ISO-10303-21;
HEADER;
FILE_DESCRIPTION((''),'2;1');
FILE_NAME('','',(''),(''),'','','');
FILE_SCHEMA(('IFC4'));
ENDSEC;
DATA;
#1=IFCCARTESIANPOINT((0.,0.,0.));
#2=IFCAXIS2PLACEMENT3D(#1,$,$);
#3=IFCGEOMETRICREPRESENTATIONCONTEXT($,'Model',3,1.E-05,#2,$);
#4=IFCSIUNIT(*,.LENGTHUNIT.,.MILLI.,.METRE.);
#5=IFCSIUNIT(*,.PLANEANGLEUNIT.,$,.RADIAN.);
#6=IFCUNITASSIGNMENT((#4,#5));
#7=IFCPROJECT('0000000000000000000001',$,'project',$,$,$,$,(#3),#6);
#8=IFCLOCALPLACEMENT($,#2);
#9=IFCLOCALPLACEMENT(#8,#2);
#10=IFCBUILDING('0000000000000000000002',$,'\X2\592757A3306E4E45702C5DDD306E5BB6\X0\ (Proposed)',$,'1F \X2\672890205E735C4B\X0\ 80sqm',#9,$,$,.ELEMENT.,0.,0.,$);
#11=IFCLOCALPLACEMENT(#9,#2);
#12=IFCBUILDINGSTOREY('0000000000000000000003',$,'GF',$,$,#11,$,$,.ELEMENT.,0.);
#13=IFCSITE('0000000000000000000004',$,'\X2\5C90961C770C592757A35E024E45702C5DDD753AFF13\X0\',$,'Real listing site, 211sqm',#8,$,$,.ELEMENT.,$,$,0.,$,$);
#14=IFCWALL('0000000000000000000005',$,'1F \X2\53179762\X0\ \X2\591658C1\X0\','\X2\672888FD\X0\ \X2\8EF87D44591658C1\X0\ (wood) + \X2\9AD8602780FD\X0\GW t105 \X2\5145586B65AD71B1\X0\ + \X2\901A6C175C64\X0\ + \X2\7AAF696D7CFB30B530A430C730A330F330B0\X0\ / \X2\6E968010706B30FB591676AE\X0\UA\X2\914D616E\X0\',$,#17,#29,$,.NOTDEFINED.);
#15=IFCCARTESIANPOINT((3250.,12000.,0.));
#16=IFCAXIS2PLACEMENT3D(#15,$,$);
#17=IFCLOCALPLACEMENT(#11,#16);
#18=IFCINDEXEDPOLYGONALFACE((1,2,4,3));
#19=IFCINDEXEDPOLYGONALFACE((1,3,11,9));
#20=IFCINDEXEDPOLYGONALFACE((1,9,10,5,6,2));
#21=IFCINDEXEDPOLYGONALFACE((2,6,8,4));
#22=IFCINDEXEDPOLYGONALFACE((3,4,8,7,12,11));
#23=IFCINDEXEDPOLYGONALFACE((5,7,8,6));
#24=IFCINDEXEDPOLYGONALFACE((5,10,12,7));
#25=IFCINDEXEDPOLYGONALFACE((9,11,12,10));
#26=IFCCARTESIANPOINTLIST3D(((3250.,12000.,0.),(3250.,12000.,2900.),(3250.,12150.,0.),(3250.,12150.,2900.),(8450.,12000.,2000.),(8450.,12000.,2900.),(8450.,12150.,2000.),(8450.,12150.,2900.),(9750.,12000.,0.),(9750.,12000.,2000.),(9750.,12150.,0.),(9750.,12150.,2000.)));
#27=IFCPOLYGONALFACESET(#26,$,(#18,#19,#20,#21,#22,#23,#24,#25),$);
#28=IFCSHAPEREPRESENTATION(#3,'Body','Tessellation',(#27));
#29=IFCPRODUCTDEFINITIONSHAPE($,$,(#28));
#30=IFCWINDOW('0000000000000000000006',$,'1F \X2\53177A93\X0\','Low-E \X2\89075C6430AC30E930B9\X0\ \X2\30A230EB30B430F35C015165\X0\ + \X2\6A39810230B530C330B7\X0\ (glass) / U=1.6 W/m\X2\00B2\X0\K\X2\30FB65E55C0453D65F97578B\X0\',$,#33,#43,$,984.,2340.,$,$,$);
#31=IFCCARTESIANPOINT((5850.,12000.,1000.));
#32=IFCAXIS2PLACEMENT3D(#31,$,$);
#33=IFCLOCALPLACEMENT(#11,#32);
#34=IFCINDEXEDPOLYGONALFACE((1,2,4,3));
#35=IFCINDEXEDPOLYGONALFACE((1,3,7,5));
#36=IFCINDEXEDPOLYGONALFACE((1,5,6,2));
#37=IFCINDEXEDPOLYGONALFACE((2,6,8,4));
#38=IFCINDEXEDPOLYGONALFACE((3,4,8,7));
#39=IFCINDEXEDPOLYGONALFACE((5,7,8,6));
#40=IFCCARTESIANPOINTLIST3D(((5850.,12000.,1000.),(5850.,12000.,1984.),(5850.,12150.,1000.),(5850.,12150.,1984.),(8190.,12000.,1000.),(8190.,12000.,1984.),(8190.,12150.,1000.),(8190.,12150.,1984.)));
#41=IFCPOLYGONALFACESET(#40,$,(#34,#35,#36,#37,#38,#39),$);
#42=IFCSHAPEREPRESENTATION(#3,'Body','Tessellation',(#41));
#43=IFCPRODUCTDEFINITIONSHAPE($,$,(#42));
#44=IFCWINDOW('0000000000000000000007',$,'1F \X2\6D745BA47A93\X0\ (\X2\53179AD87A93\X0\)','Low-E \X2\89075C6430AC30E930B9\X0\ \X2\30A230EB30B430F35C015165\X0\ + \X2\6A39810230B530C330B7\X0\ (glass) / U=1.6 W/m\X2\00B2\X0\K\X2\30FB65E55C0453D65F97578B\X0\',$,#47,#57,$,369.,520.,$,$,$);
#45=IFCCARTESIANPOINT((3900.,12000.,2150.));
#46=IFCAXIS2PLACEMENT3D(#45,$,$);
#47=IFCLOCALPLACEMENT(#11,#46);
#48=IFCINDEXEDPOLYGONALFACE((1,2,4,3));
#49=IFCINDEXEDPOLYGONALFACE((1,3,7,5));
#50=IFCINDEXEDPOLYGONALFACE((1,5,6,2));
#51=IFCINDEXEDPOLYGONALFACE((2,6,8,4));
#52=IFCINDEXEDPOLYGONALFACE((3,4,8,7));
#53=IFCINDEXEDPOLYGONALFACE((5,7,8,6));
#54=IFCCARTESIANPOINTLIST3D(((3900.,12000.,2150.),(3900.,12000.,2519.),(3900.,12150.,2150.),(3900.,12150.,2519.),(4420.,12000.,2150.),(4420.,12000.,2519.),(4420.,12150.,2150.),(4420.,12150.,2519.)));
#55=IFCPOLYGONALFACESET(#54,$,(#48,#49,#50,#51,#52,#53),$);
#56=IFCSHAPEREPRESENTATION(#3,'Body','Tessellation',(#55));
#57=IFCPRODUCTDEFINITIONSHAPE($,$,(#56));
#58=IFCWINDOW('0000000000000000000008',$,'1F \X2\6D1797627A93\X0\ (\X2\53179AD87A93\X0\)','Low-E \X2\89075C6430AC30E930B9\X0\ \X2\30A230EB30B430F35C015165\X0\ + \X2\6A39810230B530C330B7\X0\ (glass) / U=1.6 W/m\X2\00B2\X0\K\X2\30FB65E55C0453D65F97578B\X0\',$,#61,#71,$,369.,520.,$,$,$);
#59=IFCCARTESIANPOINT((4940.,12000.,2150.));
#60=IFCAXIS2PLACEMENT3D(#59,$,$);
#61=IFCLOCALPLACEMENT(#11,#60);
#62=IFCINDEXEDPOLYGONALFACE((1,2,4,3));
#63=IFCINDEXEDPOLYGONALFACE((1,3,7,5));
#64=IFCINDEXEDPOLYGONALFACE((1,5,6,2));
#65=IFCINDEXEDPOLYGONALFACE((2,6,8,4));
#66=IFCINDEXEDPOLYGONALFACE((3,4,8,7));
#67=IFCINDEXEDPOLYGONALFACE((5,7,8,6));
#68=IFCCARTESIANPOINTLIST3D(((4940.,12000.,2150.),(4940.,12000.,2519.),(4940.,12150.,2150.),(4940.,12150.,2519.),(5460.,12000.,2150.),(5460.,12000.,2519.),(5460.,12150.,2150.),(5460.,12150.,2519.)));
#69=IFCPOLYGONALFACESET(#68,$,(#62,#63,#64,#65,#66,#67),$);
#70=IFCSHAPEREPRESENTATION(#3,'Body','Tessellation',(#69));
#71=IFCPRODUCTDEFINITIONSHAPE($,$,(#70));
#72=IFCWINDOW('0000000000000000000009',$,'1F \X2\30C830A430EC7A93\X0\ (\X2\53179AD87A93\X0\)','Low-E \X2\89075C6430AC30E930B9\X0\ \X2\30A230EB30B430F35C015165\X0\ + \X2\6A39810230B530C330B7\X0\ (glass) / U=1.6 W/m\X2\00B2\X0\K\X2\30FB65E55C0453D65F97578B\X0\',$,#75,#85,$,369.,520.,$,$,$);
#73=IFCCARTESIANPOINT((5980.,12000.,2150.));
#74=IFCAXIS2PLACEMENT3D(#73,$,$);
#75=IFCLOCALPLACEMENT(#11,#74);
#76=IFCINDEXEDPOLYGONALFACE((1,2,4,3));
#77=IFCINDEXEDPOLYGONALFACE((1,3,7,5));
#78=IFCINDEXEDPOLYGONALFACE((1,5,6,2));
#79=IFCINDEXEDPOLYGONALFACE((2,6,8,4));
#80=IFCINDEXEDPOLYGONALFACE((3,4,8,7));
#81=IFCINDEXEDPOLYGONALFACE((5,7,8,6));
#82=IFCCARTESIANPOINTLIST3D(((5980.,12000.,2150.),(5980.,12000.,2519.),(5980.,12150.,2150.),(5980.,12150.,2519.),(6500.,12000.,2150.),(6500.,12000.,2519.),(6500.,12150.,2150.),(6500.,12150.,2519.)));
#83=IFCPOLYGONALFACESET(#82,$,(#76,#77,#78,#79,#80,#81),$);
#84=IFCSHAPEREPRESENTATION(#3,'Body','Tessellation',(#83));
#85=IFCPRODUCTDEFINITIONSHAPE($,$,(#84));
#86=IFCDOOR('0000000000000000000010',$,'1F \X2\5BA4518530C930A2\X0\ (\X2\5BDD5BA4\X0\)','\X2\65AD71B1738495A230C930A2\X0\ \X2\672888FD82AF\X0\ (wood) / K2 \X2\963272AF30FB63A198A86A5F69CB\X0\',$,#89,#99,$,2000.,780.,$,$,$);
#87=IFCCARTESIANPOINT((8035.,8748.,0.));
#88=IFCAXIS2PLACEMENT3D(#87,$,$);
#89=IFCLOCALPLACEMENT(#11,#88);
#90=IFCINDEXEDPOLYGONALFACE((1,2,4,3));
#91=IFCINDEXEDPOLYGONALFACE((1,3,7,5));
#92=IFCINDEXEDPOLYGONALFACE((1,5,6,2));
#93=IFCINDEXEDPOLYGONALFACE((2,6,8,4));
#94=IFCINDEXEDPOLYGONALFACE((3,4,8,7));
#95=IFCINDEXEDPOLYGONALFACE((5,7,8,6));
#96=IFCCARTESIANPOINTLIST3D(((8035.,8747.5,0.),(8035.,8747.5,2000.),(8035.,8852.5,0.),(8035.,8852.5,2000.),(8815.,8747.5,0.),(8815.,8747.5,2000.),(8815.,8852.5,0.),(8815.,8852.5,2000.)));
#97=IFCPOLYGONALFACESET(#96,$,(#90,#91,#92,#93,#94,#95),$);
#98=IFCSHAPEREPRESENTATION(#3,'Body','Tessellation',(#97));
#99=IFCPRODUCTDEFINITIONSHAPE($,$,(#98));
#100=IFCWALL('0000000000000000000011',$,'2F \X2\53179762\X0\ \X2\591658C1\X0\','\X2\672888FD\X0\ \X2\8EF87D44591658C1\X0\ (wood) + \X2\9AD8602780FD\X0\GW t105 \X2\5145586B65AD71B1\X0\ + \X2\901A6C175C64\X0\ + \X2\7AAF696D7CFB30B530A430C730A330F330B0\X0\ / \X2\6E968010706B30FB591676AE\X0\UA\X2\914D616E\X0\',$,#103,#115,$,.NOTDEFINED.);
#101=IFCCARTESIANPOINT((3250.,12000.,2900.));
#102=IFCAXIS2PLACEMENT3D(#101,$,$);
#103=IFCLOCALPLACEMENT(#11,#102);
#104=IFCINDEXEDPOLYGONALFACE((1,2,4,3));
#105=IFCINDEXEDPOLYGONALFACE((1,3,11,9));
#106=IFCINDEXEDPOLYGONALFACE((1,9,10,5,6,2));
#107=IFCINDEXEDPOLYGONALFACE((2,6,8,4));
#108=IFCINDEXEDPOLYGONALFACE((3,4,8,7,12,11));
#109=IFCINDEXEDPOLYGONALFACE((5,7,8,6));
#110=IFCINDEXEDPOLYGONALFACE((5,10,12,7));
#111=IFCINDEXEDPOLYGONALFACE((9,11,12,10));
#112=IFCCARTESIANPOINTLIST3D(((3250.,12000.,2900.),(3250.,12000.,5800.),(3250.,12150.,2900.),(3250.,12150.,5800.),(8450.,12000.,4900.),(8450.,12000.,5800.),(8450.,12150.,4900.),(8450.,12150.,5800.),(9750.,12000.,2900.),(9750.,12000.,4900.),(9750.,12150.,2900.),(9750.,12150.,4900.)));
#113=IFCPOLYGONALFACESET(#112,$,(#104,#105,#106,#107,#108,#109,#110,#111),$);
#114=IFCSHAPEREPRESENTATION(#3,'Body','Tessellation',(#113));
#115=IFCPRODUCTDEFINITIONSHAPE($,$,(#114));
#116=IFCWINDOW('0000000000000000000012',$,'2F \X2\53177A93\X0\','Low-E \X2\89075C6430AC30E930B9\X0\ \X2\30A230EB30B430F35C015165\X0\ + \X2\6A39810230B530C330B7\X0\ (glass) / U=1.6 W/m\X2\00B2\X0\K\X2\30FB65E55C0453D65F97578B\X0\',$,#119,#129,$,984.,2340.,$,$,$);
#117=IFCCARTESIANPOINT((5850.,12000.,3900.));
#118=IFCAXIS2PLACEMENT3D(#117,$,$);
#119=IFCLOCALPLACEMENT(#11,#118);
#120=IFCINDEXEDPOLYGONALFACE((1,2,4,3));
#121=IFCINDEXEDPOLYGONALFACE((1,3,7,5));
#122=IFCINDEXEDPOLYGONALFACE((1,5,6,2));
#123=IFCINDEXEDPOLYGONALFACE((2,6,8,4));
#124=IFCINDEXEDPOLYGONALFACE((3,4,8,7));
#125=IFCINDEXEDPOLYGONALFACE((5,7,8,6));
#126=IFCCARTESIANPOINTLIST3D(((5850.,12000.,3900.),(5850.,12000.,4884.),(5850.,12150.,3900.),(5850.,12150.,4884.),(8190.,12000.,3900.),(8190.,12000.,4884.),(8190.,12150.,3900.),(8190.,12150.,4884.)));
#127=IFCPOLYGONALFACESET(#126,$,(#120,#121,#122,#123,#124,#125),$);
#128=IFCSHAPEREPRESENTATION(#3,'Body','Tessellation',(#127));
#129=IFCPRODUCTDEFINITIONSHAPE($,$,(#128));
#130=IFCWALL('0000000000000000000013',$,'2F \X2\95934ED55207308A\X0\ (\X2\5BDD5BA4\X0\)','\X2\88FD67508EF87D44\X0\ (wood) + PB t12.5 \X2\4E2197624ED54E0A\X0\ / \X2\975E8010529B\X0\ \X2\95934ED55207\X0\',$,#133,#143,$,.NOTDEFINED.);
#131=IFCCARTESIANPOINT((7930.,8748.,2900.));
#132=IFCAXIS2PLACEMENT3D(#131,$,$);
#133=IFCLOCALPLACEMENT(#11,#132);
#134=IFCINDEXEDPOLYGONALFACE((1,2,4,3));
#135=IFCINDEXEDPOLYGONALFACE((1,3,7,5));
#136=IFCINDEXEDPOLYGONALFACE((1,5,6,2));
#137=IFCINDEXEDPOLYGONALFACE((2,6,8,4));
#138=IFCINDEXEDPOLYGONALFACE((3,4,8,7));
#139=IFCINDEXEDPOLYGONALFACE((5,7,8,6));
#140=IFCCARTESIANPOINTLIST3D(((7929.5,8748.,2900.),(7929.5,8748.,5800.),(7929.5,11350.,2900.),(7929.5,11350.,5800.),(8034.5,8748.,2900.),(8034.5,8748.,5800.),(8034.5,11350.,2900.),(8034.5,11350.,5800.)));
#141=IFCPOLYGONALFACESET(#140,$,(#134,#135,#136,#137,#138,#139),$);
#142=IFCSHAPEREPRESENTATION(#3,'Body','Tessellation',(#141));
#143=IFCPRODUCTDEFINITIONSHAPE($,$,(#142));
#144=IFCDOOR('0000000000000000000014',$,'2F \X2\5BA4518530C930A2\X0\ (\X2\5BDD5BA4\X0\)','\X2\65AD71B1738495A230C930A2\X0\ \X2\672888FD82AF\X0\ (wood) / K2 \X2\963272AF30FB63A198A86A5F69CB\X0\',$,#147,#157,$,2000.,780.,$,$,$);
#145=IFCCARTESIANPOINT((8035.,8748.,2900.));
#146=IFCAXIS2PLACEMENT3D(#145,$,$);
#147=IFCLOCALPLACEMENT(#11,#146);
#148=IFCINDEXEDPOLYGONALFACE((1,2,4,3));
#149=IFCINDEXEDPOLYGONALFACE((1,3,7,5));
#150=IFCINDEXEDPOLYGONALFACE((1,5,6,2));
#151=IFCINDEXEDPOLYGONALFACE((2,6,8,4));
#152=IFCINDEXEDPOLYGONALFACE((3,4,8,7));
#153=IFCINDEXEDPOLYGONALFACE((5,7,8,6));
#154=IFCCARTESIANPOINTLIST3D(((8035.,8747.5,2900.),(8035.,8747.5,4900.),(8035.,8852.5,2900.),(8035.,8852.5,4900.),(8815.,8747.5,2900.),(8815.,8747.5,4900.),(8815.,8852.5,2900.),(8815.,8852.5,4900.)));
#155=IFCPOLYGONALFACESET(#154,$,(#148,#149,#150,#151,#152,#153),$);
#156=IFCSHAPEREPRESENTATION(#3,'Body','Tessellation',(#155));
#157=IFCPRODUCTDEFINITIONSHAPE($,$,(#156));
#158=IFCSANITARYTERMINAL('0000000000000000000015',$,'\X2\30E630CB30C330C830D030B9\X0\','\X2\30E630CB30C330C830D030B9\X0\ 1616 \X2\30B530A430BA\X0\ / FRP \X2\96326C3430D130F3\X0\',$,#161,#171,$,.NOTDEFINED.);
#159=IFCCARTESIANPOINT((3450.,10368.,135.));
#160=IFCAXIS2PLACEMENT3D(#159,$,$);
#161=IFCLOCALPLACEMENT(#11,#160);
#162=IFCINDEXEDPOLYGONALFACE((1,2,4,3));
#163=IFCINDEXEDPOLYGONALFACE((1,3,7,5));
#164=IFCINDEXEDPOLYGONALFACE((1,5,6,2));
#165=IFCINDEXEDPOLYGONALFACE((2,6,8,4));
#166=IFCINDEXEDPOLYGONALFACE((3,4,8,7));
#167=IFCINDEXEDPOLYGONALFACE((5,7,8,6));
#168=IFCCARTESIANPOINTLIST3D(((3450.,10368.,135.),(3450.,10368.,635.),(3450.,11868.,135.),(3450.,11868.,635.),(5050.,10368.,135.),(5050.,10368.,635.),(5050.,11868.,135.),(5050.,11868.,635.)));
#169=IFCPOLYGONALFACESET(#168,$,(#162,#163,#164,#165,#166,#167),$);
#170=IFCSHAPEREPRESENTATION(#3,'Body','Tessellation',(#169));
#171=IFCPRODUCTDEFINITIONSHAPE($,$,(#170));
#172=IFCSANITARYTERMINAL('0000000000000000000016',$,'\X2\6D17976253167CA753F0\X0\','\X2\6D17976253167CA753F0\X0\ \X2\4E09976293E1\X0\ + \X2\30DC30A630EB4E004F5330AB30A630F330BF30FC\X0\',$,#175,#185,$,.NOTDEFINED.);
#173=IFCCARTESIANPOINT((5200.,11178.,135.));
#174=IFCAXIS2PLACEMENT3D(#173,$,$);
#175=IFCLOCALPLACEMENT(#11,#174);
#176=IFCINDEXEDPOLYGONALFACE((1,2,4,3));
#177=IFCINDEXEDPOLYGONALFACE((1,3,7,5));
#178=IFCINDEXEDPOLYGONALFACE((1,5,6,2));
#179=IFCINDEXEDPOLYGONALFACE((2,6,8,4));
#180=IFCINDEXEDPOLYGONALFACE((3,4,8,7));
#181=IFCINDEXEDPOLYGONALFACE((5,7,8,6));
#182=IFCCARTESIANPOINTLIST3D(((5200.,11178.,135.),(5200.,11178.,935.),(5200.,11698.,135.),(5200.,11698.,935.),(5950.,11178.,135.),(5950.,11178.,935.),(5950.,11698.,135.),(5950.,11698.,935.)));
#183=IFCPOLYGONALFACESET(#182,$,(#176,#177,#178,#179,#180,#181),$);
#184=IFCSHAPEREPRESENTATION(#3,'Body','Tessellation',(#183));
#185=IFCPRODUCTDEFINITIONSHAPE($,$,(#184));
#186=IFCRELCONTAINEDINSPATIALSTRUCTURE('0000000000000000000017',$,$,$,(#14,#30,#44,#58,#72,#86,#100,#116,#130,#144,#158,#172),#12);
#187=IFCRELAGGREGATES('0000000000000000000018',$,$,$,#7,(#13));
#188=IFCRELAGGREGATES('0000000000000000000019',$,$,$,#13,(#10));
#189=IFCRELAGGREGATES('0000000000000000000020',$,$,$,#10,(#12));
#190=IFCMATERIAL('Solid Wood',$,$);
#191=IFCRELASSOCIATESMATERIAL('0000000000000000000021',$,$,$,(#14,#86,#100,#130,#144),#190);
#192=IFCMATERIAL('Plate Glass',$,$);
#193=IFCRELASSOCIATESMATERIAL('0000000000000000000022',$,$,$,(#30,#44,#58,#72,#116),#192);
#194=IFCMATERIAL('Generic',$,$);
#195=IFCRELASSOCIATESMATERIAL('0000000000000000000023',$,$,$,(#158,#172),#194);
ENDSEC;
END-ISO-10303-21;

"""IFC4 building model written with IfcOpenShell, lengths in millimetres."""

from ifc_helpers import new_model, si_unit, frame, frame_2d, origin, place, context, project, spatial, rectangle, extrude, material, element, fill, save


model = new_model("IFC4")

# Units and contexts
model_context = context("Model", 3, precision=1e-05, world=origin())
ifc_project = project(units=[si_unit("LENGTHUNIT", "METRE", prefix="MILLI"), si_unit("PLANEANGLEUNIT", "RADIAN")], contexts=[model_context])

# Site, building, storey
site_placement = place(None, origin())
site = spatial("IfcSite", under=ifc_project, at=site_placement, Name="岐阜県大垣市久瀬川町３", ObjectType="Real listing site, 211sqm", CompositionType="ELEMENT", RefElevation=0.0)
building_placement = place(site_placement, origin())
building = spatial("IfcBuilding", under=site, at=building_placement, Name="大垣の久瀬川の家 (Proposed)", ObjectType="1F 木造平屋 80sqm", CompositionType="ELEMENT", ElevationOfRefHeight=0.0, ElevationOfTerrain=0.0)
storey_placement = place(building_placement, origin())
storey = spatial("IfcBuildingStorey", under=building, at=storey_placement, Name="GF", CompositionType="ELEMENT", Elevation=0.0)

# Wall, openings, windows
ifc_material_1 = material(Name="Solid Wood")
wall_1_placement = place(storey_placement, frame((3250.0, 12000.0, 0.0)))
wall_1 = element("IfcWall", 1, at=wall_1_placement, inside=storey, material=ifc_material_1, Name="1F 北面 外壁", Description="木製 軸組外壁 (wood) + 高性能GW t105 充填断熱 + 通気層 + 窯業系サイディング / 準耐火・外皮UA配慮", PredefinedType="NOTDEFINED", context=model_context, shape_type="SweptSolid", body=[
    extrude(rectangle(XDim=6500.0, YDim=150.0, at=frame_2d((3250.0, 75.0))), frame((3250.0, 12000.0, 0.0)), (0.0, 0.0, 1.0), 2900.0),
])
opening_1_placement = place(storey_placement, frame((5850.0, 12000.0, 1000.0)))
opening_1 = element("IfcOpeningElement", 2, at=opening_1_placement, cuts=wall_1, PredefinedType="NOTDEFINED", context=model_context, shape_type="SweptSolid", body=[
    extrude(rectangle(XDim=2340.0, YDim=150.0, at=frame_2d((1170.0, 75.0))), frame((5850.0, 12000.0, 1000.0)), (0.0, 0.0, 1.0), 984.0),
])
opening_2_placement = place(storey_placement, frame((3900.0, 12000.0, 2150.0)))
opening_2 = element("IfcOpeningElement", 3, at=opening_2_placement, cuts=wall_1, PredefinedType="NOTDEFINED", context=model_context, shape_type="SweptSolid", body=[
    extrude(rectangle(XDim=520.0, YDim=150.0, at=frame_2d((260.0, 75.0))), frame((3900.0, 12000.0, 2150.0)), (0.0, 0.0, 1.0), 369.0),
])
opening_3_placement = place(storey_placement, frame((4940.0, 12000.0, 2150.0)))
opening_3 = element("IfcOpeningElement", 4, at=opening_3_placement, cuts=wall_1, PredefinedType="NOTDEFINED", context=model_context, shape_type="SweptSolid", body=[
    extrude(rectangle(XDim=520.0, YDim=150.0, at=frame_2d((260.0, 75.0))), frame((4940.0, 12000.0, 2150.0)), (0.0, 0.0, 1.0), 369.0),
])
opening_4_placement = place(storey_placement, frame((5980.0, 12000.0, 2150.0)))
opening_4 = element("IfcOpeningElement", 5, at=opening_4_placement, cuts=wall_1, PredefinedType="NOTDEFINED", context=model_context, shape_type="SweptSolid", body=[
    extrude(rectangle(XDim=520.0, YDim=150.0, at=frame_2d((260.0, 75.0))), frame((5980.0, 12000.0, 2150.0)), (0.0, 0.0, 1.0), 369.0),
])
ifc_material_2 = material(Name="Plate Glass")
window_1_placement = place(storey_placement, frame((5850.0, 12000.0, 1000.0)))
window_1 = element("IfcWindow", 6, at=window_1_placement, inside=storey, material=ifc_material_2, Name="1F 北窓", Description="Low-E 複層ガラス アルゴン封入 + 樹脂サッシ (glass) / U=1.6 W/m²K・日射取得型", OverallHeight=984.0, OverallWidth=2340.0, context=model_context, shape_type="SweptSolid", body=[
    extrude(rectangle(XDim=2340.0, YDim=150.0, at=frame_2d((1170.0, 75.0))), frame((5850.0, 12000.0, 1000.0)), (0.0, 0.0, 1.0), 984.0),
])
fill(opening_1, window_1)
window_2_placement = place(storey_placement, frame((3900.0, 12000.0, 2150.0)))
window_2 = element("IfcWindow", 7, at=window_2_placement, inside=storey, material=ifc_material_2, Name="1F 浴室窓 (北高窓)", Description="Low-E 複層ガラス アルゴン封入 + 樹脂サッシ (glass) / U=1.6 W/m²K・日射取得型", OverallHeight=369.0, OverallWidth=520.0, context=model_context, shape_type="SweptSolid", body=[
    extrude(rectangle(XDim=520.0, YDim=150.0, at=frame_2d((260.0, 75.0))), frame((3900.0, 12000.0, 2150.0)), (0.0, 0.0, 1.0), 369.0),
])
fill(opening_2, window_2)
window_3_placement = place(storey_placement, frame((4940.0, 12000.0, 2150.0)))
window_3 = element("IfcWindow", 8, at=window_3_placement, inside=storey, material=ifc_material_2, Name="1F 洗面窓 (北高窓)", Description="Low-E 複層ガラス アルゴン封入 + 樹脂サッシ (glass) / U=1.6 W/m²K・日射取得型", OverallHeight=369.0, OverallWidth=520.0, context=model_context, shape_type="SweptSolid", body=[
    extrude(rectangle(XDim=520.0, YDim=150.0, at=frame_2d((260.0, 75.0))), frame((4940.0, 12000.0, 2150.0)), (0.0, 0.0, 1.0), 369.0),
])
fill(opening_3, window_3)
window_4_placement = place(storey_placement, frame((5980.0, 12000.0, 2150.0)))
window_4 = element("IfcWindow", 9, at=window_4_placement, inside=storey, material=ifc_material_2, Name="1F トイレ窓 (北高窓)", Description="Low-E 複層ガラス アルゴン封入 + 樹脂サッシ (glass) / U=1.6 W/m²K・日射取得型", OverallHeight=369.0, OverallWidth=520.0, context=model_context, shape_type="SweptSolid", body=[
    extrude(rectangle(XDim=520.0, YDim=150.0, at=frame_2d((260.0, 75.0))), frame((5980.0, 12000.0, 2150.0)), (0.0, 0.0, 1.0), 369.0),
])
fill(opening_4, window_4)

# Door
door_1_placement = place(storey_placement, frame((8035.0, 8748.0, 0.0)))
element("IfcDoor", 10, at=door_1_placement, inside=storey, material=ifc_material_1, Name="1F 室内ドア (寝室)", Description="断熱玄関ドア 木製芯 (wood) / K2 防犯・採風機構", OverallHeight=2000.0, OverallWidth=780.0, context=model_context, shape_type="SweptSolid", body=[
    extrude(rectangle(XDim=780.0, YDim=105.0, at=frame_2d((390.0, 52.0))), frame((8035.0, 8748.0, 0.0)), (0.0, 0.0, 1.0), 2000.0),
])

# Wall, opening, window
wall_2_placement = place(storey_placement, frame((3250.0, 12000.0, 2900.0)))
wall_2 = element("IfcWall", 11, at=wall_2_placement, inside=storey, material=ifc_material_1, Name="2F 北面 外壁", Description="木製 軸組外壁 (wood) + 高性能GW t105 充填断熱 + 通気層 + 窯業系サイディング / 準耐火・外皮UA配慮", PredefinedType="NOTDEFINED", context=model_context, shape_type="SweptSolid", body=[
    extrude(rectangle(XDim=6500.0, YDim=150.0, at=frame_2d((3250.0, 75.0))), frame((3250.0, 12000.0, 2900.0)), (0.0, 0.0, 1.0), 2900.0),
])
opening_5_placement = place(storey_placement, frame((5850.0, 12000.0, 3900.0)))
opening_5 = element("IfcOpeningElement", 12, at=opening_5_placement, cuts=wall_2, PredefinedType="NOTDEFINED", context=model_context, shape_type="SweptSolid", body=[
    extrude(rectangle(XDim=2340.0, YDim=150.0, at=frame_2d((1170.0, 75.0))), frame((5850.0, 12000.0, 3900.0)), (0.0, 0.0, 1.0), 984.0),
])
window_5_placement = place(storey_placement, frame((5850.0, 12000.0, 3900.0)))
window_5 = element("IfcWindow", 13, at=window_5_placement, inside=storey, material=ifc_material_2, Name="2F 北窓", Description="Low-E 複層ガラス アルゴン封入 + 樹脂サッシ (glass) / U=1.6 W/m²K・日射取得型", OverallHeight=984.0, OverallWidth=2340.0, context=model_context, shape_type="SweptSolid", body=[
    extrude(rectangle(XDim=2340.0, YDim=150.0, at=frame_2d((1170.0, 75.0))), frame((5850.0, 12000.0, 3900.0)), (0.0, 0.0, 1.0), 984.0),
])
fill(opening_5, window_5)

# Wall
wall_3_placement = place(storey_placement, frame((7930.0, 8748.0, 2900.0)))
element("IfcWall", 14, at=wall_3_placement, inside=storey, material=ifc_material_1, Name="2F 間仕切り (寝室)", Description="製材軸組 (wood) + PB t12.5 両面仕上 / 非耐力 間仕切", PredefinedType="NOTDEFINED", context=model_context, shape_type="SweptSolid", body=[
    extrude(rectangle(XDim=105.0, YDim=2602.0, at=frame_2d((52.0, 1301.0))), frame((7930.0, 8748.0, 2900.0)), (0.0, 0.0, 1.0), 2900.0),
])

# Door
door_2_placement = place(storey_placement, frame((8035.0, 8748.0, 2900.0)))
element("IfcDoor", 15, at=door_2_placement, inside=storey, material=ifc_material_1, Name="2F 室内ドア (寝室)", Description="断熱玄関ドア 木製芯 (wood) / K2 防犯・採風機構", OverallHeight=2000.0, OverallWidth=780.0, context=model_context, shape_type="SweptSolid", body=[
    extrude(rectangle(XDim=780.0, YDim=105.0, at=frame_2d((390.0, 52.0))), frame((8035.0, 8748.0, 2900.0)), (0.0, 0.0, 1.0), 2000.0),
])

# Sanitary terminals
ifc_material_3 = material(Name="Generic")
sanitary_terminal_1_placement = place(storey_placement, frame((3450.0, 10368.0, 135.0)))
element("IfcSanitaryTerminal", 16, at=sanitary_terminal_1_placement, inside=storey, material=ifc_material_3, Name="ユニットバス", Description="ユニットバス 1616 サイズ / FRP 防水パン", PredefinedType="NOTDEFINED", context=model_context, shape_type="SweptSolid", body=[
    extrude(rectangle(XDim=1600.0, YDim=1500.0, at=frame_2d((800.0, 750.0))), frame((3450.0, 10368.0, 135.0)), (0.0, 0.0, 1.0), 500.0),
])
sanitary_terminal_2_placement = place(storey_placement, frame((5200.0, 11178.0, 135.0)))
element("IfcSanitaryTerminal", 17, at=sanitary_terminal_2_placement, inside=storey, material=ifc_material_3, Name="洗面化粧台", Description="洗面化粧台 三面鏡 + ボウル一体カウンター", PredefinedType="NOTDEFINED", context=model_context, shape_type="SweptSolid", body=[
    extrude(rectangle(XDim=750.0, YDim=520.0, at=frame_2d((375.0, 260.0))), frame((5200.0, 11178.0, 135.0)), (0.0, 0.0, 1.0), 800.0),
])

save(model, "model.ifc")
